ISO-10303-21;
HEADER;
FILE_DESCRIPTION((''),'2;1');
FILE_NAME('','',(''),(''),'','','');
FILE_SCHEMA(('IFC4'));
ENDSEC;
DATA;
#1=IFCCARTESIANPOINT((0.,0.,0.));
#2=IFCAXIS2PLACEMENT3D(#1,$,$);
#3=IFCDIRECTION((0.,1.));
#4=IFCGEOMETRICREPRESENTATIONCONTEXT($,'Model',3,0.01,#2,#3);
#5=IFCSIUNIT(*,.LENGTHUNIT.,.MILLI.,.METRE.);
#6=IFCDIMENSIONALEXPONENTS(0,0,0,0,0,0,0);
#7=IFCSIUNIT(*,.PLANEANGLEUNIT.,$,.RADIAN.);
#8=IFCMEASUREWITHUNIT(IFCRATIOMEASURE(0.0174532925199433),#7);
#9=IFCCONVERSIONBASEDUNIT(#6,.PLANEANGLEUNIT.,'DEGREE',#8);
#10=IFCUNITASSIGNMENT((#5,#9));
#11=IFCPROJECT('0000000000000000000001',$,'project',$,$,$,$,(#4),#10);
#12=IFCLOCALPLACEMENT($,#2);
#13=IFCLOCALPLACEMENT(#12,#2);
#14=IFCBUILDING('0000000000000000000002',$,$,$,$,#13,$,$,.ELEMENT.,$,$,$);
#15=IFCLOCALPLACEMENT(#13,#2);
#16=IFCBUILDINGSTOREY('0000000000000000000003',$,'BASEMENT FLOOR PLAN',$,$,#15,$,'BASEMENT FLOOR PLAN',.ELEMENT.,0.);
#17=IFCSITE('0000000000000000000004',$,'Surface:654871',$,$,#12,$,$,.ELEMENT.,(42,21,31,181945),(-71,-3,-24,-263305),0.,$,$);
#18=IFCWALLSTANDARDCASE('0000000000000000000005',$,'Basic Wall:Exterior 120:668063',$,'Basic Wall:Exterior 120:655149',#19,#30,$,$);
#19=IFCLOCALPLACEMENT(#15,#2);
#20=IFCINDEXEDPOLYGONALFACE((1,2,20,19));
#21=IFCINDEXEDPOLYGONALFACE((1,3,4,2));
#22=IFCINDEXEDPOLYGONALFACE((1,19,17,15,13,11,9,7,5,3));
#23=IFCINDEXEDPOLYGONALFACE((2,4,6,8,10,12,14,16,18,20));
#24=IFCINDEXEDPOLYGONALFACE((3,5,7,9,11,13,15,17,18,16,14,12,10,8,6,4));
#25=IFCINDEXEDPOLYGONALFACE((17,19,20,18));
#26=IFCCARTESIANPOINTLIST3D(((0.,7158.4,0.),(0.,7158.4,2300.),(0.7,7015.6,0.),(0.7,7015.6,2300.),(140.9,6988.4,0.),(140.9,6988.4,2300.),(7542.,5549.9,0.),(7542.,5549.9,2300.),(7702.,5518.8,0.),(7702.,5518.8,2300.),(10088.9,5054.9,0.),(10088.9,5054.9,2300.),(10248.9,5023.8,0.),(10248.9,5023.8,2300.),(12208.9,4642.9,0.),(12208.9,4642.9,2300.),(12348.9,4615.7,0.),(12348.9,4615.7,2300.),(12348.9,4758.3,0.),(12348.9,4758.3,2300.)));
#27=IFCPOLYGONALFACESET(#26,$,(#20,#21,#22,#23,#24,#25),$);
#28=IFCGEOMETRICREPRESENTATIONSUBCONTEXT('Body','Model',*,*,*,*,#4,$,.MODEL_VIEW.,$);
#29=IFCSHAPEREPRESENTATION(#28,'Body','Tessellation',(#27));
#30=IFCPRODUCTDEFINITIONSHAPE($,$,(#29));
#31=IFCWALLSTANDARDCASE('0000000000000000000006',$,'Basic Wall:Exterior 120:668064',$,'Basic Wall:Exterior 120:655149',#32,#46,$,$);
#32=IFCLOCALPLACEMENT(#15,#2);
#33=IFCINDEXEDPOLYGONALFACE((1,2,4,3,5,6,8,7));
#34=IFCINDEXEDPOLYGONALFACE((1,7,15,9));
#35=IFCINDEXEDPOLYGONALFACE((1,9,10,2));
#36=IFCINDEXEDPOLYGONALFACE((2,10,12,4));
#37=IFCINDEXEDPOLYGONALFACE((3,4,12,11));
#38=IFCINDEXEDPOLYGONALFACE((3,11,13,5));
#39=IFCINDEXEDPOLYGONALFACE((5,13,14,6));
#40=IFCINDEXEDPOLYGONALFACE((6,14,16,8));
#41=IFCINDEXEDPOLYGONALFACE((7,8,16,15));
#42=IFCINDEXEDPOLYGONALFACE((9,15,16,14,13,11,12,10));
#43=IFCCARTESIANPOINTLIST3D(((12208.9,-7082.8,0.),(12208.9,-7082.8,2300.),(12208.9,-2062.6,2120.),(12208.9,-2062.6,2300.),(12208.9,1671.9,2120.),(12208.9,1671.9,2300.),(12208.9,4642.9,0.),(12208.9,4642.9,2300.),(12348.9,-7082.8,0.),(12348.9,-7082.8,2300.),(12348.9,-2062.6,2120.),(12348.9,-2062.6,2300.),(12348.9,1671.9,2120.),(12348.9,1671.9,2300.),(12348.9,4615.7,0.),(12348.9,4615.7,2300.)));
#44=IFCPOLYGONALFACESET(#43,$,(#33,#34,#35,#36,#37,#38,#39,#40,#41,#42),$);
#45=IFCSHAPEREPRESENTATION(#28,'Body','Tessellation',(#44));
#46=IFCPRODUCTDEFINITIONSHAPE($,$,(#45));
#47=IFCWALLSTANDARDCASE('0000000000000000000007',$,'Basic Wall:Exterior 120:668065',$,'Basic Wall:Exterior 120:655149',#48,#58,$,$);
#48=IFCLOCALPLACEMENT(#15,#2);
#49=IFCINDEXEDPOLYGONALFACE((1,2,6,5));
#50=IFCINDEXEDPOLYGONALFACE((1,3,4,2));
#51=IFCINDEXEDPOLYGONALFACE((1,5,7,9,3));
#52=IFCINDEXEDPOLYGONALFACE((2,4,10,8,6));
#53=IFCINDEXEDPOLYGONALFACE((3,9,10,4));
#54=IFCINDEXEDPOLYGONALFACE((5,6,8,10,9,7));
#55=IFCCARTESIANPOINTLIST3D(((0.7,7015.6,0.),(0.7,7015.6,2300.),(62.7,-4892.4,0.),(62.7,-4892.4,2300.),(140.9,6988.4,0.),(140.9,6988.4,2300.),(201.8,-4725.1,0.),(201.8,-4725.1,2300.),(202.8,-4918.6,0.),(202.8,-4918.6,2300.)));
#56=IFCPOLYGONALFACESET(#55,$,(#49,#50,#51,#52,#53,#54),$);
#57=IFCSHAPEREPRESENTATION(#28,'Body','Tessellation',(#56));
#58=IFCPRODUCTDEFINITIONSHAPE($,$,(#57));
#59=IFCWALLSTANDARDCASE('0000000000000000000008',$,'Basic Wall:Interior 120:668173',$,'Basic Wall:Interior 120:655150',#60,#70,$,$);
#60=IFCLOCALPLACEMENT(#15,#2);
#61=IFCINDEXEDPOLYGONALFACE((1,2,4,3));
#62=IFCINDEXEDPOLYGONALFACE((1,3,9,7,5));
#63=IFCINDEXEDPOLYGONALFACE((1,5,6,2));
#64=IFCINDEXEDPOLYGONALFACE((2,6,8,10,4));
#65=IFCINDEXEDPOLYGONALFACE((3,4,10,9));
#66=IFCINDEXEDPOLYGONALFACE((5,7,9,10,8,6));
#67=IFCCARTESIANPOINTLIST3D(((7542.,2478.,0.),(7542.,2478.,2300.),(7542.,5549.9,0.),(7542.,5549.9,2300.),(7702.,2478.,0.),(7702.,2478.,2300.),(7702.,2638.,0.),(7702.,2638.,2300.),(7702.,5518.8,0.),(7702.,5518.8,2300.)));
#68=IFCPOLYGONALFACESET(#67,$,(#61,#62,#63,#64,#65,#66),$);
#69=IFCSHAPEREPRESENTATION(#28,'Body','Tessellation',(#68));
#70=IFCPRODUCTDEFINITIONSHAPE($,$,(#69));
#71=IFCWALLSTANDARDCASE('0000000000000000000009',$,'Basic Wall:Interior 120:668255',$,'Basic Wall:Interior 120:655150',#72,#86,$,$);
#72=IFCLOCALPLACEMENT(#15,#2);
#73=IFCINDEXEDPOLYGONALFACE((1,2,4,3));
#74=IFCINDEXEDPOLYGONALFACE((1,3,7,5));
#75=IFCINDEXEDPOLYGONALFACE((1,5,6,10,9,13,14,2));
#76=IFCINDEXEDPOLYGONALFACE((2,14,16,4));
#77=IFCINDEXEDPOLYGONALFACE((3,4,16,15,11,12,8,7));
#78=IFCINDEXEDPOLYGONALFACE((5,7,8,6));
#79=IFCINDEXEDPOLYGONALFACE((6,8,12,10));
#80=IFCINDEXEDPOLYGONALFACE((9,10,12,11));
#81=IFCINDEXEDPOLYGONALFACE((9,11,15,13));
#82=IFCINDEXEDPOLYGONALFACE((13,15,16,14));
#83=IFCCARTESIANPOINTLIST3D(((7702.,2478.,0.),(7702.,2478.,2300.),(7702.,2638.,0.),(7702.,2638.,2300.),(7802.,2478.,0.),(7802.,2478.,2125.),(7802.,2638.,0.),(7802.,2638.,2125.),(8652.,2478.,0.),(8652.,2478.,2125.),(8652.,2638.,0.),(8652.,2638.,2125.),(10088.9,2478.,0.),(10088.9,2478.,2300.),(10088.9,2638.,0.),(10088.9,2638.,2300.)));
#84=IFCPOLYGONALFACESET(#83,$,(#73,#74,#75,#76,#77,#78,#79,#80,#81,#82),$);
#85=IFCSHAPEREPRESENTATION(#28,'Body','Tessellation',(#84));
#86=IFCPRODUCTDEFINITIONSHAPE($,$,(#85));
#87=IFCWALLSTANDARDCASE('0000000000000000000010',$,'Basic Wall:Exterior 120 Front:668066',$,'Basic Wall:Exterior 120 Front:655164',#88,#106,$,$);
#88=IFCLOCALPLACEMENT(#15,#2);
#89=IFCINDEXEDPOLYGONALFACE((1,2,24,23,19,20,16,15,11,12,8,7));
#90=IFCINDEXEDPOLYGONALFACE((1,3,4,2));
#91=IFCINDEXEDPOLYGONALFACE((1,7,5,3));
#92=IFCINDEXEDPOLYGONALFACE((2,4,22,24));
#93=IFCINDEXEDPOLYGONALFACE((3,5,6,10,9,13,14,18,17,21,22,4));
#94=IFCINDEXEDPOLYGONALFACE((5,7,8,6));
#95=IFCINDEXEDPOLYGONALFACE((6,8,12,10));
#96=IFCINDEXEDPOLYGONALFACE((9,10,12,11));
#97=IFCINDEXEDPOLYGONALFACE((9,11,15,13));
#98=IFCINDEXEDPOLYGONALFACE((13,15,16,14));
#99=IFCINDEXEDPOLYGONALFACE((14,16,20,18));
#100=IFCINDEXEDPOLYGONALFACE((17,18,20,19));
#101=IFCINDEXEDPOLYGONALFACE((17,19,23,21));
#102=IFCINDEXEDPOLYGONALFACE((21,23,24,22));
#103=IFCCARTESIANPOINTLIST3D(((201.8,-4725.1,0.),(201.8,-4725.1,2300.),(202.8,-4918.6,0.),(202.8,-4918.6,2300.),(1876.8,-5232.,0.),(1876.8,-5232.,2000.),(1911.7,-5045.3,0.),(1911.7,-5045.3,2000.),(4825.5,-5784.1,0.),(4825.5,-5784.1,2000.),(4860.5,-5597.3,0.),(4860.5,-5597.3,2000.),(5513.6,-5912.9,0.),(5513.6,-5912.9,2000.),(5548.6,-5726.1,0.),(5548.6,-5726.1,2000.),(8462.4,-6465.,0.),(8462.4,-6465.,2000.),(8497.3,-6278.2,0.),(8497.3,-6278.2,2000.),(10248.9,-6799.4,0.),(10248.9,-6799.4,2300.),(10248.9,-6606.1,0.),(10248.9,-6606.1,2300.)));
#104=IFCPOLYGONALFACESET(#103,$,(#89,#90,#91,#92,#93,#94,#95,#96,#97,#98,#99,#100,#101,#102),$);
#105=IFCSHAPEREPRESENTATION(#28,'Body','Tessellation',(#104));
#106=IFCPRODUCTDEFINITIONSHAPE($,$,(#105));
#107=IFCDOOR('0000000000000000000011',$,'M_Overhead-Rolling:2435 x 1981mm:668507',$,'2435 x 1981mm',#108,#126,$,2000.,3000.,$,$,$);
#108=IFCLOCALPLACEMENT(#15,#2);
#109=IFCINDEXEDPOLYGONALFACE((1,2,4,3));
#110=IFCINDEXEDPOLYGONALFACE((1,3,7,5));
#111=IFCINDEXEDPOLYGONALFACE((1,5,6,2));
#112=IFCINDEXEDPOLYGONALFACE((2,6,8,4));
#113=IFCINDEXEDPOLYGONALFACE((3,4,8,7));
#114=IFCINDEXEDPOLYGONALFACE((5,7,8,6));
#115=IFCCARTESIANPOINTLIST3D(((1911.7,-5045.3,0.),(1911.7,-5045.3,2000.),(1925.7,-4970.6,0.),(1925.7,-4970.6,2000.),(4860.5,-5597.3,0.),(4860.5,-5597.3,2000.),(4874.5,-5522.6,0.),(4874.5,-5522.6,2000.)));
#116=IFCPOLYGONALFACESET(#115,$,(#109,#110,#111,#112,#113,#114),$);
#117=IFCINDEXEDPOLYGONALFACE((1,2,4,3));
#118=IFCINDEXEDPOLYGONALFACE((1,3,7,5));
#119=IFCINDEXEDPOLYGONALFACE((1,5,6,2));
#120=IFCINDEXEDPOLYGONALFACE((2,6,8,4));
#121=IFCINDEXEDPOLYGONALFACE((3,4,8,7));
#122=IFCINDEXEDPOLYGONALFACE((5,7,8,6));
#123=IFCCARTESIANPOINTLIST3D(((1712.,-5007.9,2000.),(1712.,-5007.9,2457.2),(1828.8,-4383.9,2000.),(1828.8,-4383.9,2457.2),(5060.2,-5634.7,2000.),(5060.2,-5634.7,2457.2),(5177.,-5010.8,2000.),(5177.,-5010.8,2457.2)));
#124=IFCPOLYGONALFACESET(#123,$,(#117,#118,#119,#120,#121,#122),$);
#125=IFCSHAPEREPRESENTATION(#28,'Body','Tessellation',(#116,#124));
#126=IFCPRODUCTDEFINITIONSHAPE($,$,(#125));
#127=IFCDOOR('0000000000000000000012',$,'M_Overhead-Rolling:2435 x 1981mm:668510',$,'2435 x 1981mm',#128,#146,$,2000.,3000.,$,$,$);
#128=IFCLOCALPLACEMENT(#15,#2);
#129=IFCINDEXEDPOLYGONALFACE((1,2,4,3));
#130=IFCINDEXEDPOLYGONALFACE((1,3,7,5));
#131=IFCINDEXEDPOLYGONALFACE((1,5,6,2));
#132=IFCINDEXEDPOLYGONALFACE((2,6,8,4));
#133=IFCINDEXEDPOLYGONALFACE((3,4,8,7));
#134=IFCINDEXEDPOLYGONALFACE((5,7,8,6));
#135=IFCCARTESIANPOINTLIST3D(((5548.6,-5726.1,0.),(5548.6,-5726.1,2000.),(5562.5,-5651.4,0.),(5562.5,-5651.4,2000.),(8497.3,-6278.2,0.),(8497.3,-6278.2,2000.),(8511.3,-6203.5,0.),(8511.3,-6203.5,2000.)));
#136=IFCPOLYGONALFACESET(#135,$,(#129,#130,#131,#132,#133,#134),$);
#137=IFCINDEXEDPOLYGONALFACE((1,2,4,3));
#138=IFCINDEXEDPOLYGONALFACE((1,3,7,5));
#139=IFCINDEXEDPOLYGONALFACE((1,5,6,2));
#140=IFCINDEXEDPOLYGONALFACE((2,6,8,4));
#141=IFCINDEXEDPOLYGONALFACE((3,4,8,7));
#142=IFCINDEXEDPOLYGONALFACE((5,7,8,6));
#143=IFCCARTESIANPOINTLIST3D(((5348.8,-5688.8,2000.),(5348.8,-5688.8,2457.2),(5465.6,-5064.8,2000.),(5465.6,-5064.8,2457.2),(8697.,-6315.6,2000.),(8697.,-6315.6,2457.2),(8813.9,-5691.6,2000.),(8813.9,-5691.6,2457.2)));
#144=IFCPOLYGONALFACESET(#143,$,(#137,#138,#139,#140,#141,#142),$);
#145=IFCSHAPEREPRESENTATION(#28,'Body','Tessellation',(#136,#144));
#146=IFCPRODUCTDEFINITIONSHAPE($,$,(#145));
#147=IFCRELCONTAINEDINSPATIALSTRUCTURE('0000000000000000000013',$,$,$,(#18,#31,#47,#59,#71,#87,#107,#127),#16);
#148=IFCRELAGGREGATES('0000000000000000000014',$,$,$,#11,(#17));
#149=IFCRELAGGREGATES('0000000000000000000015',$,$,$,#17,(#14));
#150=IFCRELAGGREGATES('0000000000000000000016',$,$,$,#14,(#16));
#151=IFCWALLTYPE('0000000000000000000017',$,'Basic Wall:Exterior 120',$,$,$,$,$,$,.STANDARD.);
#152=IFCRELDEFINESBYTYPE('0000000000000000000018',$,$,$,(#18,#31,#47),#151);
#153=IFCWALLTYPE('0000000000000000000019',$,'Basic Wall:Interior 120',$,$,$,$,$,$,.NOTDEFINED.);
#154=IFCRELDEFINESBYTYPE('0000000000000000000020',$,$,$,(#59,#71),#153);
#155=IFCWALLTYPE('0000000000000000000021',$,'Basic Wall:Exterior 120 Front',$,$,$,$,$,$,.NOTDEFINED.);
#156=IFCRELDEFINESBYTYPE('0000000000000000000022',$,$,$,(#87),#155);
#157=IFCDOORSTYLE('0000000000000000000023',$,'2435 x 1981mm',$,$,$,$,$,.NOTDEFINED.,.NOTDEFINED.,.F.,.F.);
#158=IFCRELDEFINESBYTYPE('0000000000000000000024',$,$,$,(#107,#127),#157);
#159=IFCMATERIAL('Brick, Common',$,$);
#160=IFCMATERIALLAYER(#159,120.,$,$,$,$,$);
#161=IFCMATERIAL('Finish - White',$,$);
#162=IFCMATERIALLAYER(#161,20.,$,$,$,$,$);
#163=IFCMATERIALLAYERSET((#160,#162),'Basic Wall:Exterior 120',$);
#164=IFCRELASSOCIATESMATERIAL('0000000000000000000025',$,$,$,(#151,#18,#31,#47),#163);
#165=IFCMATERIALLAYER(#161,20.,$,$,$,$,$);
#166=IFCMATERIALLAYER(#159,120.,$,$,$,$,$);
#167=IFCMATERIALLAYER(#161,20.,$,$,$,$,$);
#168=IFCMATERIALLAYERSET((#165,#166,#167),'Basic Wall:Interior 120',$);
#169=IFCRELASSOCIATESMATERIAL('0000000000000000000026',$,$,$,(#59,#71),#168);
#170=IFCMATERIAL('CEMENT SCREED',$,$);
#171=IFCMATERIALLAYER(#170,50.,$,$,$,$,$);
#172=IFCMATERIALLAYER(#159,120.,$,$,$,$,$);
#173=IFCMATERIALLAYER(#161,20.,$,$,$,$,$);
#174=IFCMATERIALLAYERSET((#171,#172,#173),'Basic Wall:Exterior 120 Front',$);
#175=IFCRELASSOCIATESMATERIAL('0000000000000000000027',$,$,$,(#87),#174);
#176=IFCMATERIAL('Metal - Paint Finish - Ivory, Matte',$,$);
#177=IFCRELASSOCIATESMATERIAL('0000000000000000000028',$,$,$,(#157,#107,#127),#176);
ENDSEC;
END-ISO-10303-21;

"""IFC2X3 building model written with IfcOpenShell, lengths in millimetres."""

from ifc_helpers import new_model, entity, si_unit, converted_unit, direction, frame, frame_2d, origin, origin_2d_with_axis, place, context, subcontext, project, spatial, polyline, rectangle, outline, extrude, clip, bounded_halfspace, source, transform, mapped, material, layer, layer_set, layer_usage, type_object, type_shapes, element, fill, save


model = new_model("IFC2X3")

# Units and contexts
model_context = context("Model", 3, precision=0.01, world=origin(), true_north=direction((0.0, 1.0)))
body_context = subcontext(model_context, "Body", "Model", "MODEL_VIEW")
ifc_project = project(units=[si_unit("LENGTHUNIT", "METRE", prefix="MILLI"), converted_unit("PLANEANGLEUNIT", "DEGREE", entity("IfcRatioMeasure", 0.0174532925199433), si_unit("PLANEANGLEUNIT", "RADIAN"), dimensions=[0, 0, 0, 0, 0, 0, 0])], contexts=[model_context])

# Site, building, storey
site_placement = place(None, origin())
site = spatial("IfcSite", under=ifc_project, at=site_placement, Name="Surface:654871", CompositionType="ELEMENT", RefLatitude=(42, 21, 31, 181945), RefLongitude=(-71, -3, -24, -263305), RefElevation=0.0)
building_placement = place(site_placement, origin())
building = spatial("IfcBuilding", under=site, at=building_placement, CompositionType="ELEMENT")
storey_placement = place(building_placement, origin())
storey = spatial("IfcBuildingStorey", under=building, at=storey_placement, Name="BASEMENT FLOOR PLAN", LongName="BASEMENT FLOOR PLAN", CompositionType="ELEMENT", Elevation=0.0)

# Walls
ifc_material_1 = material(Name="Brick, Common")
ifc_layer_1 = layer(ifc_material_1, 120.0)
ifc_material_2 = material(Name="Finish - White")
ifc_layer_2 = layer(ifc_material_2, 20.0)
ifc_layer_set_1 = layer_set([ifc_layer_1, ifc_layer_2], Name="Basic Wall:Exterior 120")
ifc_layer_usage_1 = layer_usage(ifc_layer_set_1, "AXIS2", "NEGATIVE", 70.0)
wall_type_1 = type_object("IfcWallType", Name="Basic Wall:Exterior 120", PredefinedType="STANDARD", material=ifc_layer_set_1)
wall_1_placement = place(storey_placement, frame((-13.4, 7089.6, 0.0), z_axis=(0.0, 0.0, 1.0), x_axis=(0.981632, -0.190785, 0.0)))
element("IfcWallStandardCase", 1, at=wall_1_placement, inside=storey, type_object=wall_type_1, material=ifc_layer_usage_1, Name="Basic Wall:Exterior 120:668063", ObjectType="Basic Wall:Exterior 120:655149", context=body_context, shape_type="SweptSolid", body=[
    extrude(outline(polyline([(12607.1, -70.0), (12579.9, 70.0), (0.0, 70.0), (28.0, -70.0), (170.7, -70.0), (7710.3, -70.0), (7873.3, -70.0), (10304.9, -70.0), (10467.9, -70.0), (12464.5, -70.0), (12607.1, -70.0)])), origin(), (0.0, 0.0, 1.0), 2300.0),
])
ifc_layer_usage_2 = layer_usage(ifc_layer_set_1, "AXIS2", "NEGATIVE", 70.0)
wall_2_placement = place(storey_placement, frame((12278.9, 4642.9, 0.0), z_axis=(0.0, 0.0, 1.0), x_axis=(0.0, -1.0, 0.0)))
element("IfcWallStandardCase", 2, at=wall_2_placement, inside=storey, type_object=wall_type_1, material=ifc_layer_usage_2, Name="Basic Wall:Exterior 120:668064", ObjectType="Basic Wall:Exterior 120:655149", context=body_context, shape_type="Clipping", body=[
    clip(extrude(outline(polyline([(11725.7, -70.0), (11725.7, 70.0), (27.2, 70.0), (0.0, -70.0), (11725.7, -70.0)])), origin(), (0.0, 0.0, 1.0), 2300.0), bounded_halfspace(frame((2971.0, 70.0, 2120.0), z_axis=(0.0, 0.0, -1.0), x_axis=(0.190786, 0.981632, 0.0)), True, frame((2971.0, 70.0, 2120.0), z_axis=(0.0, 0.0, -1.0), x_axis=(0.190786, 0.981632, 0.0)), polyline([(0.0, 0.0), (685.1, 3525.0), (712.5, 3665.9), (575.1, 3692.7), (-137.4, 26.7), (0.0, 0.0)]))),
])
ifc_layer_usage_3 = layer_usage(ifc_layer_set_1, "AXIS2", "NEGATIVE", 70.0)
wall_3_placement = place(storey_placement, frame((132.8, -4919.0, 0.0), z_axis=(0.0, 0.0, 1.0), x_axis=(-0.0052, 0.999986, 0.0)))
element("IfcWallStandardCase", 3, at=wall_3_placement, inside=storey, type_object=wall_type_1, material=ifc_layer_usage_3, Name="Basic Wall:Exterior 120:668065", ObjectType="Basic Wall:Exterior 120:655149", context=body_context, shape_type="SweptSolid", body=[
    extrude(outline(polyline([(11907.2, -70.0), (11935.1, 70.0), (27.0, 70.0), (0.0, -70.0), (193.5, -70.0), (11907.2, -70.0)])), origin(), (0.0, 0.0, 1.0), 2300.0),
])
ifc_layer_3 = layer(ifc_material_2, 20.0)
ifc_layer_4 = layer(ifc_material_1, 120.0)
ifc_layer_5 = layer(ifc_material_2, 20.0)
ifc_layer_set_2 = layer_set([ifc_layer_3, ifc_layer_4, ifc_layer_5], Name="Basic Wall:Interior 120")
ifc_layer_usage_4 = layer_usage(ifc_layer_set_2, "AXIS2", "NEGATIVE", 80.0)
wall_type_2 = type_object("IfcWallType", Name="Basic Wall:Interior 120", PredefinedType="NOTDEFINED")
wall_4_placement = place(storey_placement, frame((7622.0, 5549.9, 0.0), z_axis=(0.0, 0.0, 1.0), x_axis=(0.0, -1.0, 0.0)))
element("IfcWallStandardCase", 4, at=wall_4_placement, inside=storey, type_object=wall_type_2, material=ifc_layer_usage_4, Name="Basic Wall:Interior 120:668173", ObjectType="Basic Wall:Interior 120:655150", context=body_context, shape_type="SweptSolid", body=[
    extrude(outline(polyline([(3071.9, -80.0), (3071.9, 80.0), (2911.9, 80.0), (31.1, 80.0), (0.0, -80.0), (3071.9, -80.0)])), origin(), (0.0, 0.0, 1.0), 2300.0),
])

# Wall, opening
ifc_layer_usage_5 = layer_usage(ifc_layer_set_2, "AXIS2", "NEGATIVE", 80.0)
wall_5_placement = place(storey_placement, frame((7702.0, 2558.0, 0.0)))
wall_5 = element("IfcWallStandardCase", 5, at=wall_5_placement, inside=storey, type_object=wall_type_2, material=ifc_layer_usage_5, Name="Basic Wall:Interior 120:668255", ObjectType="Basic Wall:Interior 120:655150", context=body_context, shape_type="SweptSolid", body=[
    extrude(rectangle(XDim=2386.9, YDim=160.0, at=frame_2d((1193.5, 0.0), x_axis=(-1.0, 0.0))), origin(), (0.0, 0.0, 1.0), 2300.0),
])
opening_1_placement = place(wall_5_placement, frame((100.0, -80.0, 0.0)))
element("IfcOpeningElement", 6, at=opening_1_placement, cuts=wall_5, ObjectType="Opening", context=body_context, shape_type="SweptSolid", body=[
    extrude(rectangle(XDim=2125.0, YDim=850.0, at=frame_2d((1062.5, 425.0), x_axis=(1.0, 0.0))), frame((0.0, 0.0, 0.0), z_axis=(0.0, 1.0, 0.0), x_axis=(0.0, 0.0, 1.0)), (0.0, 0.0, 1.0), 160.0),
])

# Wall, openings, doors
ifc_material_3 = material(Name="CEMENT SCREED")
ifc_layer_6 = layer(ifc_material_3, 50.0)
ifc_layer_7 = layer(ifc_material_1, 120.0)
ifc_layer_8 = layer(ifc_material_2, 20.0)
ifc_layer_set_3 = layer_set([ifc_layer_6, ifc_layer_7, ifc_layer_8], Name="Basic Wall:Exterior 120 Front")
ifc_layer_usage_6 = layer_usage(ifc_layer_set_3, "AXIS2", "NEGATIVE", 95.0)
wall_type_3 = type_object("IfcWallType", Name="Basic Wall:Exterior 120 Front", PredefinedType="NOTDEFINED")
wall_6_placement = place(storey_placement, frame((10266.4, -6706.1, 0.0), z_axis=(0.0, 0.0, 1.0), x_axis=(-0.982923, 0.184019, 0.0)))
wall_6 = element("IfcWallStandardCase", 7, at=wall_6_placement, inside=storey, type_object=wall_type_3, material=ifc_layer_usage_6, Name="Basic Wall:Exterior 120 Front:668066", ObjectType="Basic Wall:Exterior 120 Front:655164", context=body_context, shape_type="SweptSolid", body=[
    extrude(outline(polyline([(35.6, -95.0), (55.9, -95.0), (10257.3, -95.0), (10220.7, 95.0), (0.0, 95.0), (35.6, -95.0)])), origin(), (0.0, 0.0, 1.0), 2300.0),
])
opening_2_placement = place(wall_6_placement, frame((8517.6, 95.0, 0.0)))
opening_2 = element("IfcOpeningElement", 8, at=opening_2_placement, cuts=wall_6, ObjectType="Opening", context=body_context, shape_type="SweptSolid", body=[
    extrude(rectangle(XDim=2000.0, YDim=3000.0, at=frame_2d((1000.0, 1500.0), x_axis=(1.0, 0.0))), frame((0.0, 0.0, 0.0), z_axis=(0.0, -1.0, 0.0), x_axis=(0.0, 0.0, 1.0)), (0.0, 0.0, 1.0), 190.0),
])
opening_3_placement = place(wall_6_placement, frame((4817.6, 95.0, 0.0)))
opening_3 = element("IfcOpeningElement", 9, at=opening_3_placement, cuts=wall_6, ObjectType="Opening", context=body_context, shape_type="SweptSolid", body=[
    extrude(rectangle(XDim=2000.0, YDim=3000.0, at=frame_2d((1000.0, 1500.0), x_axis=(1.0, 0.0))), frame((0.0, 0.0, 0.0), z_axis=(0.0, -1.0, 0.0), x_axis=(0.0, 0.0, 1.0)), (0.0, 0.0, 1.0), 190.0),
])
ifc_material_4 = material(Name="Metal - Paint Finish - Ivory, Matte")
door_style = type_object("IfcDoorStyle", Name="2435 x 1981mm", ConstructionType="NOTDEFINED", OperationType="NOTDEFINED", ParameterTakesPrecedence=False, Sizeable=False, material=ifc_material_4)
shared_shape = source(origin(), body_context, "Body", "SweptSolid", [
    extrude(rectangle(XDim=3000.0, YDim=76.0, at=frame_2d((0.0, 0.0), x_axis=(1.0, 0.0))), frame((1500.0, -38.0, 0.0), z_axis=(0.0, 0.0, 1.0), x_axis=(-1.0, 0.0, 0.0)), (0.0, 0.0, 1.0), 2000.0),
    extrude(rectangle(XDim=634.8, YDim=3406.4, at=origin_2d_with_axis()), frame((1500.0, -317.4, 2000.0), z_axis=(0.0, 0.0, 1.0), x_axis=(0.0, 1.0, 0.0)), (0.0, 0.0, 1.0), 457.2),
])
type_shapes(door_style, [shared_shape])
door_1_placement = place(opening_2_placement, frame((-3000.0, -190.0, 0.0)))
door_1 = element("IfcDoor", 10, at=door_1_placement, inside=storey, type_object=door_style, material=ifc_material_4, Name="M_Overhead-Rolling:2435 x 1981mm:668507", ObjectType="2435 x 1981mm", OverallHeight=2000.0, OverallWidth=3000.0, context=body_context, shape_type="MappedRepresentation", body=[
    mapped(shared_shape, transform((0.0, 0.0, 0.0), scale=1.0)),
])
fill(opening_2, door_1)
door_2_placement = place(opening_3_placement, frame((-3000.0, -190.0, 0.0)))
door_2 = element("IfcDoor", 11, at=door_2_placement, inside=storey, type_object=door_style, material=ifc_material_4, Name="M_Overhead-Rolling:2435 x 1981mm:668510", ObjectType="2435 x 1981mm", OverallHeight=2000.0, OverallWidth=3000.0, context=body_context, shape_type="MappedRepresentation", body=[
    mapped(shared_shape, transform((0.0, 0.0, 0.0), scale=1.0)),
])
fill(opening_3, door_2)

save(model, "model.ifc")
